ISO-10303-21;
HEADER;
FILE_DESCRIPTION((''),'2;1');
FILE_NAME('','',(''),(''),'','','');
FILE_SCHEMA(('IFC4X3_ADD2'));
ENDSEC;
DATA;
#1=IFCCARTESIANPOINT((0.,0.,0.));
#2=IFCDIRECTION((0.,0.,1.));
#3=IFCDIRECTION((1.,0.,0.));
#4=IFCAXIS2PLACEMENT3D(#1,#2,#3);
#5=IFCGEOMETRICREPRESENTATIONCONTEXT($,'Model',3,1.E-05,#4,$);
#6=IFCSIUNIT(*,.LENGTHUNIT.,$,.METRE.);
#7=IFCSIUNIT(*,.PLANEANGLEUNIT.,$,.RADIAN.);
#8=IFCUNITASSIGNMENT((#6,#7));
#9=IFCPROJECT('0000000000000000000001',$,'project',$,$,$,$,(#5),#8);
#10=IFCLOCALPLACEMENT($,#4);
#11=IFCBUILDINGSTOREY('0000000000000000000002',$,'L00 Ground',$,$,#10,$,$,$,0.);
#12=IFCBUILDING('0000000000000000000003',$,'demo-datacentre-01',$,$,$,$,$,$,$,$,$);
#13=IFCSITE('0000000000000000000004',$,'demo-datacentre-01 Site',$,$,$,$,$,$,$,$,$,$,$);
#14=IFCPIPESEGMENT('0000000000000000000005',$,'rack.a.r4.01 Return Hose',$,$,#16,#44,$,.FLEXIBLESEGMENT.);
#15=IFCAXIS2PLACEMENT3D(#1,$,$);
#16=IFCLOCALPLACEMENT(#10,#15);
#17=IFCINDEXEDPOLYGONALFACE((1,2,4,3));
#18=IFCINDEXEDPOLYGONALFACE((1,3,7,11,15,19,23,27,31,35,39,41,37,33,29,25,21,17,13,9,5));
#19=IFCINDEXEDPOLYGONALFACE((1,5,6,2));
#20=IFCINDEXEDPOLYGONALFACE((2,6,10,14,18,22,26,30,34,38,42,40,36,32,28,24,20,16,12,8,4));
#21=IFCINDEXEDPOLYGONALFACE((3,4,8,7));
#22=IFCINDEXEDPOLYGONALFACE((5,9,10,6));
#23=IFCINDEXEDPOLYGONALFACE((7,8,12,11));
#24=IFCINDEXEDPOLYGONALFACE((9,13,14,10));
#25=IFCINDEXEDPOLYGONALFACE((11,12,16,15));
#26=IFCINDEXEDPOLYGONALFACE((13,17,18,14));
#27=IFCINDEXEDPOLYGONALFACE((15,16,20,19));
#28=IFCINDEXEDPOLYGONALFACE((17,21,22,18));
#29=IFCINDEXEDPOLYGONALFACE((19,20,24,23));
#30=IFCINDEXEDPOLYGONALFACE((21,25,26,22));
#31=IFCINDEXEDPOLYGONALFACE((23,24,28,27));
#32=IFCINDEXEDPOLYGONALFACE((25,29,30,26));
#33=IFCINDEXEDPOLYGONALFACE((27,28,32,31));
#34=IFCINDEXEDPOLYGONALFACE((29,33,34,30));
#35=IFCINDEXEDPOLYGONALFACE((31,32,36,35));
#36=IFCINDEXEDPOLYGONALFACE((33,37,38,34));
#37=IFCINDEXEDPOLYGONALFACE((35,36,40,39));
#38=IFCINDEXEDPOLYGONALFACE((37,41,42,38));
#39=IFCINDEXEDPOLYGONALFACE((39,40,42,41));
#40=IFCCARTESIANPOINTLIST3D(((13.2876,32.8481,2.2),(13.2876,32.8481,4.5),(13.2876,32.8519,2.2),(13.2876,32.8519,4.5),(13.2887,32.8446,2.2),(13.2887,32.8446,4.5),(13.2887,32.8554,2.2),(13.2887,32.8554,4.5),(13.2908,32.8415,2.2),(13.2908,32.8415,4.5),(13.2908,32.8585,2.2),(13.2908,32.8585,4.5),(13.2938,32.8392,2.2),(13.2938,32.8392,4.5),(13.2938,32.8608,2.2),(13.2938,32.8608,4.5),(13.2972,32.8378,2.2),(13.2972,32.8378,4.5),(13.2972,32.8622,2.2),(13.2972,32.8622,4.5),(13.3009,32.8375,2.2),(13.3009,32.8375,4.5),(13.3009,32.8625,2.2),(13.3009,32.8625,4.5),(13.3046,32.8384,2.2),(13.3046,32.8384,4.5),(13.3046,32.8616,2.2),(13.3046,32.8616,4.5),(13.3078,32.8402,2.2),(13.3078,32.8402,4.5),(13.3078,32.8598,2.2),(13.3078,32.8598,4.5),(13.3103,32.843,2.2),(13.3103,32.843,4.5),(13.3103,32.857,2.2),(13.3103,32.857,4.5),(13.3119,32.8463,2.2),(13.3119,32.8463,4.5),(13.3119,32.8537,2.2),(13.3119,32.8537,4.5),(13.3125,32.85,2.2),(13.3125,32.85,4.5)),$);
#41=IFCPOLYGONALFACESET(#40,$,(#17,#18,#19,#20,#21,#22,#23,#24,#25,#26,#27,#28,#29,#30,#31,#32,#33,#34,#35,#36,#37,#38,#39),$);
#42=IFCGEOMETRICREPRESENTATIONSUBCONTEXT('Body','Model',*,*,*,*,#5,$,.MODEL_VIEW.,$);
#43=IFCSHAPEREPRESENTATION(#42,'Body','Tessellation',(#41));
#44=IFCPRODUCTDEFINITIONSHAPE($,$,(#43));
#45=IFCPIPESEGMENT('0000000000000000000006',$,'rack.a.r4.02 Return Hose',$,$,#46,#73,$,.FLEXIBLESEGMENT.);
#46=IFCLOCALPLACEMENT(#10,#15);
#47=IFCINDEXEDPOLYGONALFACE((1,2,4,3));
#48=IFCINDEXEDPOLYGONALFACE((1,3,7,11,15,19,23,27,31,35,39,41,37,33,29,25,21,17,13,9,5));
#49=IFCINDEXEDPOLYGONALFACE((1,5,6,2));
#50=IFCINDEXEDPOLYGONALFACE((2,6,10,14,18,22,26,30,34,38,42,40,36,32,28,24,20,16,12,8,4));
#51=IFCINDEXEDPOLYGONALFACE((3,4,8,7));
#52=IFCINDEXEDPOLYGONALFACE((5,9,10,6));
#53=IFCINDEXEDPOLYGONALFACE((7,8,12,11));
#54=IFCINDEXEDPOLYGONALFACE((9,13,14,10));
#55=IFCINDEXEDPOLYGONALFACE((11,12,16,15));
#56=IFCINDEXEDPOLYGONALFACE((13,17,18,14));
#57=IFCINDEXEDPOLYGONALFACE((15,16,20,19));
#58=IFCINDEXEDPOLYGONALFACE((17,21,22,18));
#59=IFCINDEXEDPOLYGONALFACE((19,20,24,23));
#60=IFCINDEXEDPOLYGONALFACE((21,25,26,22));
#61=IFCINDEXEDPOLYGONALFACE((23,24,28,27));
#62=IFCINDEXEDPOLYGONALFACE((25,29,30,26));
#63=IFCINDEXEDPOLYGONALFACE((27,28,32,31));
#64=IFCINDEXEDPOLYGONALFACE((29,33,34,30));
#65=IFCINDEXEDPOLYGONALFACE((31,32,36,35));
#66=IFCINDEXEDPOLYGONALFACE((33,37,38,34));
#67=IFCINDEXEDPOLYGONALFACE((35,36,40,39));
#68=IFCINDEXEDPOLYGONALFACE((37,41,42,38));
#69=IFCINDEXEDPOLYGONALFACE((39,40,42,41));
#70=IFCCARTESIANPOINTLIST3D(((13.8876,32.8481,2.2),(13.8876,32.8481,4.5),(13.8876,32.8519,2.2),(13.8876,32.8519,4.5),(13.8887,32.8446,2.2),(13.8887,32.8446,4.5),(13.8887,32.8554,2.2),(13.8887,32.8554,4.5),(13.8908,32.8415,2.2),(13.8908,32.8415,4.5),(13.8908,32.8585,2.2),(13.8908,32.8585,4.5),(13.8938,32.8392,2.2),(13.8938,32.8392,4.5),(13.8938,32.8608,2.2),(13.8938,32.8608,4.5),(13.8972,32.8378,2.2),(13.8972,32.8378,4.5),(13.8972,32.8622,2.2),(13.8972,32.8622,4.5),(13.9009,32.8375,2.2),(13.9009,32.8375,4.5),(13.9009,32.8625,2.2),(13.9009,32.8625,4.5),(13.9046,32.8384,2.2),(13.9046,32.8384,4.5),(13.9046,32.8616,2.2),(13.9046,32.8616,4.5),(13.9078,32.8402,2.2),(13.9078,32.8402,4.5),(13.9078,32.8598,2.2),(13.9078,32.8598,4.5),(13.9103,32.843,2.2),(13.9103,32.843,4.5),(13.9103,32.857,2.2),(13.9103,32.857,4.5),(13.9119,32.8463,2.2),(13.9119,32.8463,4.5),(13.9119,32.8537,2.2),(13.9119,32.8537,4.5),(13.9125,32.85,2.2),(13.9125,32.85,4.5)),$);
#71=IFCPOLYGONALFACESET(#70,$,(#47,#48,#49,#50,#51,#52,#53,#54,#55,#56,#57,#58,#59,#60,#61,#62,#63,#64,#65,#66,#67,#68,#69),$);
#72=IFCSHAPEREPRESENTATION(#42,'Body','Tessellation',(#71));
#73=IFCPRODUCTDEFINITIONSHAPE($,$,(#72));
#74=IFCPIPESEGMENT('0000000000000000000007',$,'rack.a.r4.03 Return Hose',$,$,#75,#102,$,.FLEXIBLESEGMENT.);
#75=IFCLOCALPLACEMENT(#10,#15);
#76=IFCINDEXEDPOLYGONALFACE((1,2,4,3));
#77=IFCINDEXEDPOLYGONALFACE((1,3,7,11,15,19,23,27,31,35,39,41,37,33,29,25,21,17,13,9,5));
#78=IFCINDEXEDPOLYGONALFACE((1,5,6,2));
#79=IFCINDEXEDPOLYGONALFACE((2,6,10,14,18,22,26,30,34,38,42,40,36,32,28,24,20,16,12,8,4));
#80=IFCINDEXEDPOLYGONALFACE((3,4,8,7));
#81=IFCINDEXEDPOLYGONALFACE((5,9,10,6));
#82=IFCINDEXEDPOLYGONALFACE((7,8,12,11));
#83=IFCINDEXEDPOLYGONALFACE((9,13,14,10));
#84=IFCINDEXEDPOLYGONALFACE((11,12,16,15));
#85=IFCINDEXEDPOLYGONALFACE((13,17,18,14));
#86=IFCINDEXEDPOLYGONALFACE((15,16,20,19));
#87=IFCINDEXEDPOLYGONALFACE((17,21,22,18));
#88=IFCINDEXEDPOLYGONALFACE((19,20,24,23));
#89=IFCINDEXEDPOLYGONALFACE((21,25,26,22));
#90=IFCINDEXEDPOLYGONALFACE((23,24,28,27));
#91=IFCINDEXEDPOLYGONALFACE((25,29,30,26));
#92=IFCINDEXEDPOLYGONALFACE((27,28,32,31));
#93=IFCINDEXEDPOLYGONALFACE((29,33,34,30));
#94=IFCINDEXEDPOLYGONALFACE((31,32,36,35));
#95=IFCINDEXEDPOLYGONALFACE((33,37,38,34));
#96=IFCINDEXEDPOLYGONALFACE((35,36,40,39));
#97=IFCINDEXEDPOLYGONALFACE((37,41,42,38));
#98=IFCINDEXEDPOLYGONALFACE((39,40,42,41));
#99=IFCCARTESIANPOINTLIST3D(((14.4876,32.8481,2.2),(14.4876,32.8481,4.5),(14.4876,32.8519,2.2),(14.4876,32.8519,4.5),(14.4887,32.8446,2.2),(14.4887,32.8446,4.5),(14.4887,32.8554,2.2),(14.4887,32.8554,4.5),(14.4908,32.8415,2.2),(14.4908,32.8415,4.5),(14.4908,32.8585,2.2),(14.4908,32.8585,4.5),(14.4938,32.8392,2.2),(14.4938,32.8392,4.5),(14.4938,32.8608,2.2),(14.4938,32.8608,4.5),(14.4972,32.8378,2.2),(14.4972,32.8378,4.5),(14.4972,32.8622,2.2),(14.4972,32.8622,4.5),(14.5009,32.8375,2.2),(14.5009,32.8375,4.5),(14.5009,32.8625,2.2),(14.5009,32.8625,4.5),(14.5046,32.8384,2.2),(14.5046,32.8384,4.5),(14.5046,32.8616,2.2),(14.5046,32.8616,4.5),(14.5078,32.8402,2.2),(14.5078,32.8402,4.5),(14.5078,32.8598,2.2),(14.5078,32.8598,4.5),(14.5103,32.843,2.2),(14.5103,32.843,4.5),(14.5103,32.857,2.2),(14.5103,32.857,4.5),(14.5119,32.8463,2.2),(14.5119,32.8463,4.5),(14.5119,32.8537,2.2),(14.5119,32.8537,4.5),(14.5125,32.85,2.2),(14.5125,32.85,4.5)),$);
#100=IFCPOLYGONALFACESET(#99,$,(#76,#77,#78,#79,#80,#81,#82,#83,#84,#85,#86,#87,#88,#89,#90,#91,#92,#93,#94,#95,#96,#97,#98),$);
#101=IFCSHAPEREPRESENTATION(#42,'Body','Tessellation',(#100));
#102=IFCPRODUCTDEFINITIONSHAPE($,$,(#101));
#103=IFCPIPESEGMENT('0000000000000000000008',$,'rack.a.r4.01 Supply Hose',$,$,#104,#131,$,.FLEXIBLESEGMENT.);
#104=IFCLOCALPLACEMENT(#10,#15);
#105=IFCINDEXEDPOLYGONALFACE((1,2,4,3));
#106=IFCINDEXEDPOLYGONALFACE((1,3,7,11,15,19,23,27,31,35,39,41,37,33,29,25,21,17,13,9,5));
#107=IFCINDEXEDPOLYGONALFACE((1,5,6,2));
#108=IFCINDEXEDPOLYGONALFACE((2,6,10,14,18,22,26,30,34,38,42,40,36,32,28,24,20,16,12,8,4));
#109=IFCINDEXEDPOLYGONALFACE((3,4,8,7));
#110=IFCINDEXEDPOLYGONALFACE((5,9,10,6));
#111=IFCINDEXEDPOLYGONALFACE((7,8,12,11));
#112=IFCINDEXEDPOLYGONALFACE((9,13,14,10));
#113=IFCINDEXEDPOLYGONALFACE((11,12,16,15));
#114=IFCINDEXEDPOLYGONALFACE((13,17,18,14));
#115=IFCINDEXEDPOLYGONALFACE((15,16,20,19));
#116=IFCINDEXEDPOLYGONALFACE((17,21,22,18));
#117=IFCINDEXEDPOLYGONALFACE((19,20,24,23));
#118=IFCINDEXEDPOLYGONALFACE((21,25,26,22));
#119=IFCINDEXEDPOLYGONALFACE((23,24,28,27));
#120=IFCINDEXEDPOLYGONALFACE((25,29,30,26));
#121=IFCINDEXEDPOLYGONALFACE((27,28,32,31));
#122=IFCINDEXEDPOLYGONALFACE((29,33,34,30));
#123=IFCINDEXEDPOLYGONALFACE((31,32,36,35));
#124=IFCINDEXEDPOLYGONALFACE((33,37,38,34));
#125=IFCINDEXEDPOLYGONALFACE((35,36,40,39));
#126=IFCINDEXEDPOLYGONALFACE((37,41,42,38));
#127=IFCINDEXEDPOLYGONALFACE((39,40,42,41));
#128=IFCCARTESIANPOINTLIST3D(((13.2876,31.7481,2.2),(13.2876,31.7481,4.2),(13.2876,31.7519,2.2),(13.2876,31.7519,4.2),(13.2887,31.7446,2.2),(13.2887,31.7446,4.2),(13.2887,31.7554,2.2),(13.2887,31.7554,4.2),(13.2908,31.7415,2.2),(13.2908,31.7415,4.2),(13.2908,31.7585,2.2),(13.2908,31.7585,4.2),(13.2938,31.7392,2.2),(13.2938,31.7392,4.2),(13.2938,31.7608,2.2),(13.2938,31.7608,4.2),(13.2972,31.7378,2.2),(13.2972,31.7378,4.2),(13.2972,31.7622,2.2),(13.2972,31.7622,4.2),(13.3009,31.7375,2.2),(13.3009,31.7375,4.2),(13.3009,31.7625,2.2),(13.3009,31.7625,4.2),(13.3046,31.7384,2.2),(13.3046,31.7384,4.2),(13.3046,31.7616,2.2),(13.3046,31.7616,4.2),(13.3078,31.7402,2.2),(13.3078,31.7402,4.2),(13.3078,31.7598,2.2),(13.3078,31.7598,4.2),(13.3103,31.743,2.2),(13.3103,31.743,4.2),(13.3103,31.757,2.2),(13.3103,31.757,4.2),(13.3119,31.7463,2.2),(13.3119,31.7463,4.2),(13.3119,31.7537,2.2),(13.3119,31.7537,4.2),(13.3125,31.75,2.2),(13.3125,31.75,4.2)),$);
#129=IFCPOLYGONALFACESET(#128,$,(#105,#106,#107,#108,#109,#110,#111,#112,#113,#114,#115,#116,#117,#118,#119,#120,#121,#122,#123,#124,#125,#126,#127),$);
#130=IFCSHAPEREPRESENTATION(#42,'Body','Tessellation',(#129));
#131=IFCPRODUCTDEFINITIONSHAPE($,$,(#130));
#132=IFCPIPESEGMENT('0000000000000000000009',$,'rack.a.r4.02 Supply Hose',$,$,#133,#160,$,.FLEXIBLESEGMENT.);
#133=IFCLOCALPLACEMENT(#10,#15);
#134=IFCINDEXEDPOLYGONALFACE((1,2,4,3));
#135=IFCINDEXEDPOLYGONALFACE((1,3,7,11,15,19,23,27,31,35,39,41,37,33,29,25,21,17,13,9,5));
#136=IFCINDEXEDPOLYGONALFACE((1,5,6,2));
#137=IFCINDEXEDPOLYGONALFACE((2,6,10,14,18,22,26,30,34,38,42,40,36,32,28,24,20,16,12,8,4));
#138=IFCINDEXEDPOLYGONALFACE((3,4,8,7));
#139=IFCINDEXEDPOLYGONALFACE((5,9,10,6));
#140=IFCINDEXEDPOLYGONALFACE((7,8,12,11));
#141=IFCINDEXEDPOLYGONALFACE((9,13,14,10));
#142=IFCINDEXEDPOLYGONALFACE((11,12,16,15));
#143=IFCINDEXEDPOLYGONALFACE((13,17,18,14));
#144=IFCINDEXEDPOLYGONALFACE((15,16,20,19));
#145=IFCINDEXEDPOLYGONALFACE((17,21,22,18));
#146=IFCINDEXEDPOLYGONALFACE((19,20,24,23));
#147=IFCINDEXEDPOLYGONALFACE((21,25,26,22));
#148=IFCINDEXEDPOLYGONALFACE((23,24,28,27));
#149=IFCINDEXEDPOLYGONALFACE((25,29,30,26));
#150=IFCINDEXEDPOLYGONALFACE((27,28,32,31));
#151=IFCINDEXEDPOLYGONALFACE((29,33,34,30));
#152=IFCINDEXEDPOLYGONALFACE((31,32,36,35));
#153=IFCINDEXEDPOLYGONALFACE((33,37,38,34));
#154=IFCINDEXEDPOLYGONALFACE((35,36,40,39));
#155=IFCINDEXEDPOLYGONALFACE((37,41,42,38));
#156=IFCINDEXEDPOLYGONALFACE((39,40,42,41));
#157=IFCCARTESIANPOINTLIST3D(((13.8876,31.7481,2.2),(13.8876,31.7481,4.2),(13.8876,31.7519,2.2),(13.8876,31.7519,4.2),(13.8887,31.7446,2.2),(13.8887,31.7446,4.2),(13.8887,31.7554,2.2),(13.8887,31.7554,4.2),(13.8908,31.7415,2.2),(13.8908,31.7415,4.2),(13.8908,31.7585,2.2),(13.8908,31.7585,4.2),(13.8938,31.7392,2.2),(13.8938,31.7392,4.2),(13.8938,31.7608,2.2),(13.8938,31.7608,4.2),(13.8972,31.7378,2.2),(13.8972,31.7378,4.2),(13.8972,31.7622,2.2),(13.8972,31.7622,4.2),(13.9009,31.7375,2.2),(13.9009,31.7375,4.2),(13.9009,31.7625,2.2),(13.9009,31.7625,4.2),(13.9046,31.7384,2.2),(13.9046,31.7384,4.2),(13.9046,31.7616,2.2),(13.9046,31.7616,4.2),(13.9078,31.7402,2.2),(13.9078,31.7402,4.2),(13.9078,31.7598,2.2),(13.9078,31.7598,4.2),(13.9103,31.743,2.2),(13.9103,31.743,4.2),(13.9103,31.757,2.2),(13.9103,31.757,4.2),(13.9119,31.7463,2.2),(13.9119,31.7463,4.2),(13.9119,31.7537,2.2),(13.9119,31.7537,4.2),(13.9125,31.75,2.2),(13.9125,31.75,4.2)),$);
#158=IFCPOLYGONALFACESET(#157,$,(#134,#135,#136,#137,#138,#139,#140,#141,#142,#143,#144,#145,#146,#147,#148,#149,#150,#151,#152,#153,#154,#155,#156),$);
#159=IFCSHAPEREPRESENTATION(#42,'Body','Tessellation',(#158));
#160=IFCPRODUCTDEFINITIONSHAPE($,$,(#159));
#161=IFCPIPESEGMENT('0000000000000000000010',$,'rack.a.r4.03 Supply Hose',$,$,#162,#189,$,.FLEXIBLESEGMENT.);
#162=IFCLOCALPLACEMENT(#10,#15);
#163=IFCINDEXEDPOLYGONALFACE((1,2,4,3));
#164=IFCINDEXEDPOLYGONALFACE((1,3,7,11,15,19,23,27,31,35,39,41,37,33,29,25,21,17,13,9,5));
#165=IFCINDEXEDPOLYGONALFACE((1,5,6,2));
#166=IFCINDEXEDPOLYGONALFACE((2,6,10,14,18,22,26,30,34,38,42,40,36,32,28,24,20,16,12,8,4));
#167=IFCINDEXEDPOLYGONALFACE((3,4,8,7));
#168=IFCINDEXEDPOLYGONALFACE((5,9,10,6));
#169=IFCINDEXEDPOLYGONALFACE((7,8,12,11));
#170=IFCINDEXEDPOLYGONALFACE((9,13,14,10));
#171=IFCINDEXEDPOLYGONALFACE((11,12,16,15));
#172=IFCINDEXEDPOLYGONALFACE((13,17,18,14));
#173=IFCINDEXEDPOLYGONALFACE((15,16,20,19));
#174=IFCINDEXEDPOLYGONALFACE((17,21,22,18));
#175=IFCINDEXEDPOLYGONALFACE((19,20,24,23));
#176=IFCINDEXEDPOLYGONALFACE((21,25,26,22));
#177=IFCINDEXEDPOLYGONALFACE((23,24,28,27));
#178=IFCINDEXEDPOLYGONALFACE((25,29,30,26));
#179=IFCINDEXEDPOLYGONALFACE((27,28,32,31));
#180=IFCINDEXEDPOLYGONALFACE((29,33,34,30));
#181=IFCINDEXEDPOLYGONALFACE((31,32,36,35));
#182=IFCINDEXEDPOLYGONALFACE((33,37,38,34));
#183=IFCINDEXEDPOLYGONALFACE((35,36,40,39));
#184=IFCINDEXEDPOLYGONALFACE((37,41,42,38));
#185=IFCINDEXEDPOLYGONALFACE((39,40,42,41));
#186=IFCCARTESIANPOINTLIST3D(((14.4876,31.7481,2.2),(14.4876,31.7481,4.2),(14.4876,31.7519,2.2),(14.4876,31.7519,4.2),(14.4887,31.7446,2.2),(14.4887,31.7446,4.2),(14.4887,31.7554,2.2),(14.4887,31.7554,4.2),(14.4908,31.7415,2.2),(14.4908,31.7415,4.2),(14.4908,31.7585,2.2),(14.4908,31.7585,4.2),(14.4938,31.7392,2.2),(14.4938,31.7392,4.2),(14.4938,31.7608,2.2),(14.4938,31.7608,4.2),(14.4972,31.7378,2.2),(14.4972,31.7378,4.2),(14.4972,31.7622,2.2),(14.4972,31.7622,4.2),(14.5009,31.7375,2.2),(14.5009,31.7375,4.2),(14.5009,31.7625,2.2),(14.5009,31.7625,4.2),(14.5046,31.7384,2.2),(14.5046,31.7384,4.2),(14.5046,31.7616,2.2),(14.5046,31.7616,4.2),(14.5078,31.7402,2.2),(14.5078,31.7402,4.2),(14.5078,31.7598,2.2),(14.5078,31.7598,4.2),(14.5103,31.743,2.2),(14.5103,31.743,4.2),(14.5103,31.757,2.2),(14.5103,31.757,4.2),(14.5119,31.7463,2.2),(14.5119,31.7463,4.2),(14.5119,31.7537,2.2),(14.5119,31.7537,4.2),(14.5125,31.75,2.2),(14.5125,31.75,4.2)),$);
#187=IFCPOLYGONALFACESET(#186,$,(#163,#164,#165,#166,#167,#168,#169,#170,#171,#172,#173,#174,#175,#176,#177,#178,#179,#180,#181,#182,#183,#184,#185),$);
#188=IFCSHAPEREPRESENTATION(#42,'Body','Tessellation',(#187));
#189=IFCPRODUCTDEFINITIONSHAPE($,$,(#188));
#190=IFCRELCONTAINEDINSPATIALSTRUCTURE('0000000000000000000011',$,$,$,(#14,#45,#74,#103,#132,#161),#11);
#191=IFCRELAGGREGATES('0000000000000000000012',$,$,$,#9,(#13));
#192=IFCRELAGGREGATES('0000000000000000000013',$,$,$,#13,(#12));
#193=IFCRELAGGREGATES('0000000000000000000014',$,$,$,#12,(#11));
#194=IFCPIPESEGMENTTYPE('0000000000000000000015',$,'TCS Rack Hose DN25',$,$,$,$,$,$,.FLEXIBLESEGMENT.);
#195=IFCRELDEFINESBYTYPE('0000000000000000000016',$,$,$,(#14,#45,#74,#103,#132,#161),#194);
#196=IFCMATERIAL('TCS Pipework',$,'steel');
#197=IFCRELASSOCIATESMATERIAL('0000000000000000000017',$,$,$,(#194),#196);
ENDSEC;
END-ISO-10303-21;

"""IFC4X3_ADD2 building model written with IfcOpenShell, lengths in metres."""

from ifc_helpers import new_model, si_unit, frame, origin_with_axes, place, context, subcontext, project, spatial, circle, extrude, material, type_object, element, save


model = new_model("IFC4X3_ADD2")

# Units and contexts
model_context = context("Model", 3, precision=1e-05, world=origin_with_axes())
body_context = subcontext(model_context, "Body", "Model", "MODEL_VIEW")
ifc_project = project(units=[si_unit("LENGTHUNIT", "METRE"), si_unit("PLANEANGLEUNIT", "RADIAN")], contexts=[model_context])

# Site, building, storey
site = spatial("IfcSite", under=ifc_project, Name="demo-datacentre-01 Site")
building = spatial("IfcBuilding", under=site, Name="demo-datacentre-01")
storey_placement = place(None, origin_with_axes())
storey = spatial("IfcBuildingStorey", under=building, at=storey_placement, Name="L00 Ground", Elevation=0.0)

# Shared definitions
ifc_material = material(Name="TCS Pipework", Category="steel")

# Pipe segments
pipe_segment_type_1 = type_object("IfcPipeSegmentType", Name="TCS Rack Hose DN25", PredefinedType="FLEXIBLESEGMENT", material=ifc_material)
for number, where, z_axis, x_axis, name in (
    (1, (13.3, 32.85, 4.5), (0.0, 0.0, -1.0), (1.0, 0.0, 0.0), "rack.a.r4.01 Return Hose"),
    (2, (13.9, 32.85, 4.5), (0.0, 0.0, -1.0), (1.0, 0.0, 0.0), "rack.a.r4.02 Return Hose"),
    (3, (14.5, 32.85, 4.5), (0.0, 0.0, -1.0), (1.0, 0.0, 0.0), "rack.a.r4.03 Return Hose"),
):
    element("IfcPipeSegment", number, at=place(storey_placement, frame(where, z_axis=z_axis, x_axis=x_axis)), inside=storey, type_object=pipe_segment_type_1, Name=name, PredefinedType="FLEXIBLESEGMENT", context=body_context, shape_type="SweptSolid", body=[
        extrude(circle(Radius=0.0125), origin_with_axes(), (0.0, 0.0, 1.0), 2.3),
    ])
for number, where, z_axis, x_axis, name in (
    (4, (13.3, 31.75, 4.2), (0.0, 0.0, -1.0), (1.0, 0.0, 0.0), "rack.a.r4.01 Supply Hose"),
    (5, (13.9, 31.75, 4.2), (0.0, 0.0, -1.0), (1.0, 0.0, 0.0), "rack.a.r4.02 Supply Hose"),
    (6, (14.5, 31.75, 4.2), (0.0, 0.0, -1.0), (1.0, 0.0, 0.0), "rack.a.r4.03 Supply Hose"),
):
    element("IfcPipeSegment", number, at=place(storey_placement, frame(where, z_axis=z_axis, x_axis=x_axis)), inside=storey, type_object=pipe_segment_type_1, Name=name, PredefinedType="FLEXIBLESEGMENT", context=body_context, shape_type="SweptSolid", body=[
        extrude(circle(Radius=0.0125), origin_with_axes(), (0.0, 0.0, 1.0), 2.0),
    ])

save(model, "model.ifc")
